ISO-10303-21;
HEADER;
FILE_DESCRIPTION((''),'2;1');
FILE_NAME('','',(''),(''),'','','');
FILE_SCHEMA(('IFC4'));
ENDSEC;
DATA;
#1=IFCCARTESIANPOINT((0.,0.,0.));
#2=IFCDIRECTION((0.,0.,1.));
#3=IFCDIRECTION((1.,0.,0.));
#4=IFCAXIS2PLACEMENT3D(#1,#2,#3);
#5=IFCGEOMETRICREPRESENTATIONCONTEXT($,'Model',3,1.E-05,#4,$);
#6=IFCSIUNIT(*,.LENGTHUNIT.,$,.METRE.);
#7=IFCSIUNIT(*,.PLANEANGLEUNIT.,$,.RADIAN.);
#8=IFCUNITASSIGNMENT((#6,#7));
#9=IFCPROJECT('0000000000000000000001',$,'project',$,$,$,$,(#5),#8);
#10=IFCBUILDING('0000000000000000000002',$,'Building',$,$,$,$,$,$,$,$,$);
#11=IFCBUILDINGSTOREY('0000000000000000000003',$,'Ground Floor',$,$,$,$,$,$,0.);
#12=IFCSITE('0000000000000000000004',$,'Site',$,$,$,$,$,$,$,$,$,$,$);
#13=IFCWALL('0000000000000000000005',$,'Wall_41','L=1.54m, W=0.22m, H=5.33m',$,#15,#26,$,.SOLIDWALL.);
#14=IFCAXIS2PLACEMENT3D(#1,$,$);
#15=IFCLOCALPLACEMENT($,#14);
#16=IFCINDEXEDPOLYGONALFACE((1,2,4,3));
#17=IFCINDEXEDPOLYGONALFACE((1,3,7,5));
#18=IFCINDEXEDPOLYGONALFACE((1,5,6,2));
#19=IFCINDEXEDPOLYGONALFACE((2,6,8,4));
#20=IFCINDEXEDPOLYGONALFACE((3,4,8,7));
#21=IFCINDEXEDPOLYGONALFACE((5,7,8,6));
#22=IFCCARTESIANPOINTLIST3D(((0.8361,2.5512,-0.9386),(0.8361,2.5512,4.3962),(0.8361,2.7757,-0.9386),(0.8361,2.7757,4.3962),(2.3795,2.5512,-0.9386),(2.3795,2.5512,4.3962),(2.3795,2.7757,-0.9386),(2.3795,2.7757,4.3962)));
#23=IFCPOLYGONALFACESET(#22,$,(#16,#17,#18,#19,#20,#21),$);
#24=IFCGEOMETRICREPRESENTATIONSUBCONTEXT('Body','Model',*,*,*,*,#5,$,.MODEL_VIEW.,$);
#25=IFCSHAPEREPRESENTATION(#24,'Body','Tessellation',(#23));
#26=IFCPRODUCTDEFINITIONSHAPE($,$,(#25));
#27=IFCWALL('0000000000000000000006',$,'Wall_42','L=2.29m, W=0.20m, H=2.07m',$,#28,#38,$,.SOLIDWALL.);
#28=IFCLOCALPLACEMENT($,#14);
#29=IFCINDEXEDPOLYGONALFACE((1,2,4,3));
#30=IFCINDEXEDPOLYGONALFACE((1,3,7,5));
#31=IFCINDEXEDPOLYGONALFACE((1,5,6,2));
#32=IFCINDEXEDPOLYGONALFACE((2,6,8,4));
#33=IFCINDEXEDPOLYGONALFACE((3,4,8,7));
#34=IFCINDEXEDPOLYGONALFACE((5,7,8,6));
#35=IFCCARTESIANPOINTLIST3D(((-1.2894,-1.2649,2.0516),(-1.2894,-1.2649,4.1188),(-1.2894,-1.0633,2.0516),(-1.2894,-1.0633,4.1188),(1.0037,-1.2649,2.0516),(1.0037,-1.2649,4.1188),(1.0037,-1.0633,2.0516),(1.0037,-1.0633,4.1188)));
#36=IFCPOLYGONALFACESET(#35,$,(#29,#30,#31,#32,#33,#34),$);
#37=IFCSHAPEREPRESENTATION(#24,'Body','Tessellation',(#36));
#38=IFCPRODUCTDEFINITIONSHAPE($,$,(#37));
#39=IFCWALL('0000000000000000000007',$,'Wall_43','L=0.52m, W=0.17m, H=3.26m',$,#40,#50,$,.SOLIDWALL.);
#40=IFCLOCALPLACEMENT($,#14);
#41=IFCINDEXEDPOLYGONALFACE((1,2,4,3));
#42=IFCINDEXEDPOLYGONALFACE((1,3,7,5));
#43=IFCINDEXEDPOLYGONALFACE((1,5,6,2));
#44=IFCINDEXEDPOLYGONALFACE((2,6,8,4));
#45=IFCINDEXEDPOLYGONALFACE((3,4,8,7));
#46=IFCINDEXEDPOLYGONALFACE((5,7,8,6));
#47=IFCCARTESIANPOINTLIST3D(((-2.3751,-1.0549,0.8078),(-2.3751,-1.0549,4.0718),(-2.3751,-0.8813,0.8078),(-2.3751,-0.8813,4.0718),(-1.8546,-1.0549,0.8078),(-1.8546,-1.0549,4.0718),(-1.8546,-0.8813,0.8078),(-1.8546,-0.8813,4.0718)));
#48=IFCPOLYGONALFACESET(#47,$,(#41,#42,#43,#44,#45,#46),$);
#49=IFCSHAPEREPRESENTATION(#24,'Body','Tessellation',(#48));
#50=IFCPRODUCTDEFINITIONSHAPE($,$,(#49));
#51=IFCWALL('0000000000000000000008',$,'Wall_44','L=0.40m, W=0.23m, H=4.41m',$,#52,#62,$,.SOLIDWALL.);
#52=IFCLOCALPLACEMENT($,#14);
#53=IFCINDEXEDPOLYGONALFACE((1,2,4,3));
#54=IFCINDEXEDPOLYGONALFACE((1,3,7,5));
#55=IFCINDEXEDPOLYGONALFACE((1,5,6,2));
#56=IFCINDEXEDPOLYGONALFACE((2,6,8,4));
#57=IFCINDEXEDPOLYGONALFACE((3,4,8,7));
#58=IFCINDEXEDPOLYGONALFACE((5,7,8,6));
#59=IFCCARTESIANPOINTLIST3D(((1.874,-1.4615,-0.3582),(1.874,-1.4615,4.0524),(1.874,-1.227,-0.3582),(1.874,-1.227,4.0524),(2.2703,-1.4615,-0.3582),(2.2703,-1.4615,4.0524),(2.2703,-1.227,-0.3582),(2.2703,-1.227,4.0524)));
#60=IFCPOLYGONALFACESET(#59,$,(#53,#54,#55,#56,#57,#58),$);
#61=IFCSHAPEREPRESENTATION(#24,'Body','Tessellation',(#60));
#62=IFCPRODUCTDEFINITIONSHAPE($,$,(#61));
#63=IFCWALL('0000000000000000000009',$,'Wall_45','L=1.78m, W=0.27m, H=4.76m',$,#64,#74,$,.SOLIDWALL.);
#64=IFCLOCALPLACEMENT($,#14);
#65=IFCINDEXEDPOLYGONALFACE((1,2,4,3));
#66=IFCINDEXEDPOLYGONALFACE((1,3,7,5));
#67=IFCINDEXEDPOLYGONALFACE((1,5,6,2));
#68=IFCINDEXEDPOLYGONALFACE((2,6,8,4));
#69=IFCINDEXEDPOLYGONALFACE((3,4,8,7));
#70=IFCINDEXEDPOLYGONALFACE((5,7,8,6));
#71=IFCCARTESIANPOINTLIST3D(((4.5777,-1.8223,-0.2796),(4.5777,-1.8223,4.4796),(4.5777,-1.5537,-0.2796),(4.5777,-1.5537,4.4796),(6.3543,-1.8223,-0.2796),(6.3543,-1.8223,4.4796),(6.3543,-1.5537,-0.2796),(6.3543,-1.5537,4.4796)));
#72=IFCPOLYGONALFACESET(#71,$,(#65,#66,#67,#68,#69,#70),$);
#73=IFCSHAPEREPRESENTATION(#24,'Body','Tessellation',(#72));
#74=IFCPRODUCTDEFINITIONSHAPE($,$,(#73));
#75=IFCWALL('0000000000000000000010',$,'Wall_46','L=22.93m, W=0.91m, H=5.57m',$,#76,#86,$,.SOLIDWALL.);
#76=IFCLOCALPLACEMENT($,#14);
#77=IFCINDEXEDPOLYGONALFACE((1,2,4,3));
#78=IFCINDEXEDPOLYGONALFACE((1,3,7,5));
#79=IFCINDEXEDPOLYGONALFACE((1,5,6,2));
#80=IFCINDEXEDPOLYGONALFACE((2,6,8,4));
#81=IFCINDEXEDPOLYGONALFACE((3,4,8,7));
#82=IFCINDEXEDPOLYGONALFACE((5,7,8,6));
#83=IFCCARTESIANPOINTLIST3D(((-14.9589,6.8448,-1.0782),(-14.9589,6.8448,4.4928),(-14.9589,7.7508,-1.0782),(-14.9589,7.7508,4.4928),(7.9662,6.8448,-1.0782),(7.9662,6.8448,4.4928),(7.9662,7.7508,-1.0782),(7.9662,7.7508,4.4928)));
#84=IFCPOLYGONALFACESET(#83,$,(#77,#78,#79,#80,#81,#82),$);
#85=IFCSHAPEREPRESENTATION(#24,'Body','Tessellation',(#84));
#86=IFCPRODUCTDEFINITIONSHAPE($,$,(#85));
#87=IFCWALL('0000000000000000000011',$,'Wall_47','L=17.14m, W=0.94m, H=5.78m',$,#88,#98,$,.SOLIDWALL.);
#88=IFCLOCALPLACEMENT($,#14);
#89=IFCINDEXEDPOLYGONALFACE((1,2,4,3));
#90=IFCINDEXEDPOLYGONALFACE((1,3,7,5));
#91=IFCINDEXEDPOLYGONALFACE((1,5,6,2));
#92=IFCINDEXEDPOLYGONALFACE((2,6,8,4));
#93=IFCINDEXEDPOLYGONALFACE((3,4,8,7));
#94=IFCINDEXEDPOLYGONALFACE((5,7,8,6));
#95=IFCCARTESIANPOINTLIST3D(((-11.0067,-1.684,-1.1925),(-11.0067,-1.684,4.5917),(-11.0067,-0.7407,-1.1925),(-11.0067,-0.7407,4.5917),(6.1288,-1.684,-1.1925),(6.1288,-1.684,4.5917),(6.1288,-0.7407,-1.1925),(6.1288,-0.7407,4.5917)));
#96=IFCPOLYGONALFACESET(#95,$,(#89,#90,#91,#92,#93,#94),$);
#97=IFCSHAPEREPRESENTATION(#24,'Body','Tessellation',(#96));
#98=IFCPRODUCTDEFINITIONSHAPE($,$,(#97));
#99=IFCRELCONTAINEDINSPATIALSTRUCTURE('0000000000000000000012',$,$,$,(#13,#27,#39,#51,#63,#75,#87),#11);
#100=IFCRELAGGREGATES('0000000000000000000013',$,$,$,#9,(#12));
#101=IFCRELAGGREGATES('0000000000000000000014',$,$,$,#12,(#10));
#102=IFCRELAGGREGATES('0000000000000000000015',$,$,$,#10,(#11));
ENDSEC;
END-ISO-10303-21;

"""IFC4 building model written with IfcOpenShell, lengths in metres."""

from ifc_helpers import new_model, si_unit, frame, origin_with_axes, origin_2d, context, subcontext, project, spatial, rectangle, extrude, element, save


model = new_model("IFC4")

# Units and contexts
model_context = context("Model", 3, precision=1e-05, world=origin_with_axes())
body_context = subcontext(model_context, "Body", "Model", "MODEL_VIEW")
ifc_project = project(units=[si_unit("LENGTHUNIT", "METRE"), si_unit("PLANEANGLEUNIT", "RADIAN")], contexts=[model_context])

# Site, building, storey
site = spatial("IfcSite", under=ifc_project, Name="Site")
building = spatial("IfcBuilding", under=site, Name="Building")
storey = spatial("IfcBuildingStorey", under=building, Name="Ground Floor", Elevation=0.0)

# Walls
element("IfcWall", 1, inside=storey, Name="Wall_41", Description="L=1.54m, W=0.22m, H=5.33m", PredefinedType="SOLIDWALL", context=body_context, shape_type="SweptSolid", body=[
    extrude(rectangle(XDim=1.5434, YDim=0.2246, at=origin_2d()), frame((1.6078, 2.6634, -0.9386), z_axis=(0.0, 0.0, 1.0), x_axis=(1.0, 0.0, 0.0)), (0.0, 0.0, 1.0), 5.3348),
])
element("IfcWall", 2, inside=storey, Name="Wall_42", Description="L=2.29m, W=0.20m, H=2.07m", PredefinedType="SOLIDWALL", context=body_context, shape_type="SweptSolid", body=[
    extrude(rectangle(XDim=2.293, YDim=0.2016, at=origin_2d()), frame((-0.1429, -1.1641, 2.0516), z_axis=(0.0, 0.0, 1.0), x_axis=(1.0, 0.0, 0.0)), (0.0, 0.0, 1.0), 2.0672),
])
element("IfcWall", 3, inside=storey, Name="Wall_43", Description="L=0.52m, W=0.17m, H=3.26m", PredefinedType="SOLIDWALL", context=body_context, shape_type="SweptSolid", body=[
    extrude(rectangle(XDim=0.5205, YDim=0.1736, at=origin_2d()), frame((-2.1148, -0.9681, 0.8078), z_axis=(0.0, 0.0, 1.0), x_axis=(1.0, 0.0, 0.0)), (0.0, 0.0, 1.0), 3.264),
])
element("IfcWall", 4, inside=storey, Name="Wall_44", Description="L=0.40m, W=0.23m, H=4.41m", PredefinedType="SOLIDWALL", context=body_context, shape_type="SweptSolid", body=[
    extrude(rectangle(XDim=0.3962, YDim=0.2344, at=origin_2d()), frame((2.0721, -1.3442, -0.3582), z_axis=(0.0, 0.0, 1.0), x_axis=(1.0, 0.0, 0.0)), (0.0, 0.0, 1.0), 4.4106),
])
element("IfcWall", 5, inside=storey, Name="Wall_45", Description="L=1.78m, W=0.27m, H=4.76m", PredefinedType="SOLIDWALL", context=body_context, shape_type="SweptSolid", body=[
    extrude(rectangle(XDim=1.7765, YDim=0.2686, at=origin_2d()), frame((5.466, -1.688, -0.2796), z_axis=(0.0, 0.0, 1.0), x_axis=(1.0, 0.0, 0.0)), (0.0, 0.0, 1.0), 4.7592),
])
element("IfcWall", 6, inside=storey, Name="Wall_46", Description="L=22.93m, W=0.91m, H=5.57m", PredefinedType="SOLIDWALL", context=body_context, shape_type="SweptSolid", body=[
    extrude(rectangle(XDim=22.9251, YDim=0.906, at=origin_2d()), frame((-3.4964, 7.2978, -1.0782), z_axis=(0.0, 0.0, 1.0), x_axis=(1.0, 0.0, 0.0)), (0.0, 0.0, 1.0), 5.571),
])
element("IfcWall", 7, inside=storey, Name="Wall_47", Description="L=17.14m, W=0.94m, H=5.78m", PredefinedType="SOLIDWALL", context=body_context, shape_type="SweptSolid", body=[
    extrude(rectangle(XDim=17.1355, YDim=0.9433, at=origin_2d()), frame((-2.4389, -1.2124, -1.1925), z_axis=(0.0, 0.0, 1.0), x_axis=(1.0, 0.0, 0.0)), (0.0, 0.0, 1.0), 5.7842),
])

save(model, "model.ifc")
